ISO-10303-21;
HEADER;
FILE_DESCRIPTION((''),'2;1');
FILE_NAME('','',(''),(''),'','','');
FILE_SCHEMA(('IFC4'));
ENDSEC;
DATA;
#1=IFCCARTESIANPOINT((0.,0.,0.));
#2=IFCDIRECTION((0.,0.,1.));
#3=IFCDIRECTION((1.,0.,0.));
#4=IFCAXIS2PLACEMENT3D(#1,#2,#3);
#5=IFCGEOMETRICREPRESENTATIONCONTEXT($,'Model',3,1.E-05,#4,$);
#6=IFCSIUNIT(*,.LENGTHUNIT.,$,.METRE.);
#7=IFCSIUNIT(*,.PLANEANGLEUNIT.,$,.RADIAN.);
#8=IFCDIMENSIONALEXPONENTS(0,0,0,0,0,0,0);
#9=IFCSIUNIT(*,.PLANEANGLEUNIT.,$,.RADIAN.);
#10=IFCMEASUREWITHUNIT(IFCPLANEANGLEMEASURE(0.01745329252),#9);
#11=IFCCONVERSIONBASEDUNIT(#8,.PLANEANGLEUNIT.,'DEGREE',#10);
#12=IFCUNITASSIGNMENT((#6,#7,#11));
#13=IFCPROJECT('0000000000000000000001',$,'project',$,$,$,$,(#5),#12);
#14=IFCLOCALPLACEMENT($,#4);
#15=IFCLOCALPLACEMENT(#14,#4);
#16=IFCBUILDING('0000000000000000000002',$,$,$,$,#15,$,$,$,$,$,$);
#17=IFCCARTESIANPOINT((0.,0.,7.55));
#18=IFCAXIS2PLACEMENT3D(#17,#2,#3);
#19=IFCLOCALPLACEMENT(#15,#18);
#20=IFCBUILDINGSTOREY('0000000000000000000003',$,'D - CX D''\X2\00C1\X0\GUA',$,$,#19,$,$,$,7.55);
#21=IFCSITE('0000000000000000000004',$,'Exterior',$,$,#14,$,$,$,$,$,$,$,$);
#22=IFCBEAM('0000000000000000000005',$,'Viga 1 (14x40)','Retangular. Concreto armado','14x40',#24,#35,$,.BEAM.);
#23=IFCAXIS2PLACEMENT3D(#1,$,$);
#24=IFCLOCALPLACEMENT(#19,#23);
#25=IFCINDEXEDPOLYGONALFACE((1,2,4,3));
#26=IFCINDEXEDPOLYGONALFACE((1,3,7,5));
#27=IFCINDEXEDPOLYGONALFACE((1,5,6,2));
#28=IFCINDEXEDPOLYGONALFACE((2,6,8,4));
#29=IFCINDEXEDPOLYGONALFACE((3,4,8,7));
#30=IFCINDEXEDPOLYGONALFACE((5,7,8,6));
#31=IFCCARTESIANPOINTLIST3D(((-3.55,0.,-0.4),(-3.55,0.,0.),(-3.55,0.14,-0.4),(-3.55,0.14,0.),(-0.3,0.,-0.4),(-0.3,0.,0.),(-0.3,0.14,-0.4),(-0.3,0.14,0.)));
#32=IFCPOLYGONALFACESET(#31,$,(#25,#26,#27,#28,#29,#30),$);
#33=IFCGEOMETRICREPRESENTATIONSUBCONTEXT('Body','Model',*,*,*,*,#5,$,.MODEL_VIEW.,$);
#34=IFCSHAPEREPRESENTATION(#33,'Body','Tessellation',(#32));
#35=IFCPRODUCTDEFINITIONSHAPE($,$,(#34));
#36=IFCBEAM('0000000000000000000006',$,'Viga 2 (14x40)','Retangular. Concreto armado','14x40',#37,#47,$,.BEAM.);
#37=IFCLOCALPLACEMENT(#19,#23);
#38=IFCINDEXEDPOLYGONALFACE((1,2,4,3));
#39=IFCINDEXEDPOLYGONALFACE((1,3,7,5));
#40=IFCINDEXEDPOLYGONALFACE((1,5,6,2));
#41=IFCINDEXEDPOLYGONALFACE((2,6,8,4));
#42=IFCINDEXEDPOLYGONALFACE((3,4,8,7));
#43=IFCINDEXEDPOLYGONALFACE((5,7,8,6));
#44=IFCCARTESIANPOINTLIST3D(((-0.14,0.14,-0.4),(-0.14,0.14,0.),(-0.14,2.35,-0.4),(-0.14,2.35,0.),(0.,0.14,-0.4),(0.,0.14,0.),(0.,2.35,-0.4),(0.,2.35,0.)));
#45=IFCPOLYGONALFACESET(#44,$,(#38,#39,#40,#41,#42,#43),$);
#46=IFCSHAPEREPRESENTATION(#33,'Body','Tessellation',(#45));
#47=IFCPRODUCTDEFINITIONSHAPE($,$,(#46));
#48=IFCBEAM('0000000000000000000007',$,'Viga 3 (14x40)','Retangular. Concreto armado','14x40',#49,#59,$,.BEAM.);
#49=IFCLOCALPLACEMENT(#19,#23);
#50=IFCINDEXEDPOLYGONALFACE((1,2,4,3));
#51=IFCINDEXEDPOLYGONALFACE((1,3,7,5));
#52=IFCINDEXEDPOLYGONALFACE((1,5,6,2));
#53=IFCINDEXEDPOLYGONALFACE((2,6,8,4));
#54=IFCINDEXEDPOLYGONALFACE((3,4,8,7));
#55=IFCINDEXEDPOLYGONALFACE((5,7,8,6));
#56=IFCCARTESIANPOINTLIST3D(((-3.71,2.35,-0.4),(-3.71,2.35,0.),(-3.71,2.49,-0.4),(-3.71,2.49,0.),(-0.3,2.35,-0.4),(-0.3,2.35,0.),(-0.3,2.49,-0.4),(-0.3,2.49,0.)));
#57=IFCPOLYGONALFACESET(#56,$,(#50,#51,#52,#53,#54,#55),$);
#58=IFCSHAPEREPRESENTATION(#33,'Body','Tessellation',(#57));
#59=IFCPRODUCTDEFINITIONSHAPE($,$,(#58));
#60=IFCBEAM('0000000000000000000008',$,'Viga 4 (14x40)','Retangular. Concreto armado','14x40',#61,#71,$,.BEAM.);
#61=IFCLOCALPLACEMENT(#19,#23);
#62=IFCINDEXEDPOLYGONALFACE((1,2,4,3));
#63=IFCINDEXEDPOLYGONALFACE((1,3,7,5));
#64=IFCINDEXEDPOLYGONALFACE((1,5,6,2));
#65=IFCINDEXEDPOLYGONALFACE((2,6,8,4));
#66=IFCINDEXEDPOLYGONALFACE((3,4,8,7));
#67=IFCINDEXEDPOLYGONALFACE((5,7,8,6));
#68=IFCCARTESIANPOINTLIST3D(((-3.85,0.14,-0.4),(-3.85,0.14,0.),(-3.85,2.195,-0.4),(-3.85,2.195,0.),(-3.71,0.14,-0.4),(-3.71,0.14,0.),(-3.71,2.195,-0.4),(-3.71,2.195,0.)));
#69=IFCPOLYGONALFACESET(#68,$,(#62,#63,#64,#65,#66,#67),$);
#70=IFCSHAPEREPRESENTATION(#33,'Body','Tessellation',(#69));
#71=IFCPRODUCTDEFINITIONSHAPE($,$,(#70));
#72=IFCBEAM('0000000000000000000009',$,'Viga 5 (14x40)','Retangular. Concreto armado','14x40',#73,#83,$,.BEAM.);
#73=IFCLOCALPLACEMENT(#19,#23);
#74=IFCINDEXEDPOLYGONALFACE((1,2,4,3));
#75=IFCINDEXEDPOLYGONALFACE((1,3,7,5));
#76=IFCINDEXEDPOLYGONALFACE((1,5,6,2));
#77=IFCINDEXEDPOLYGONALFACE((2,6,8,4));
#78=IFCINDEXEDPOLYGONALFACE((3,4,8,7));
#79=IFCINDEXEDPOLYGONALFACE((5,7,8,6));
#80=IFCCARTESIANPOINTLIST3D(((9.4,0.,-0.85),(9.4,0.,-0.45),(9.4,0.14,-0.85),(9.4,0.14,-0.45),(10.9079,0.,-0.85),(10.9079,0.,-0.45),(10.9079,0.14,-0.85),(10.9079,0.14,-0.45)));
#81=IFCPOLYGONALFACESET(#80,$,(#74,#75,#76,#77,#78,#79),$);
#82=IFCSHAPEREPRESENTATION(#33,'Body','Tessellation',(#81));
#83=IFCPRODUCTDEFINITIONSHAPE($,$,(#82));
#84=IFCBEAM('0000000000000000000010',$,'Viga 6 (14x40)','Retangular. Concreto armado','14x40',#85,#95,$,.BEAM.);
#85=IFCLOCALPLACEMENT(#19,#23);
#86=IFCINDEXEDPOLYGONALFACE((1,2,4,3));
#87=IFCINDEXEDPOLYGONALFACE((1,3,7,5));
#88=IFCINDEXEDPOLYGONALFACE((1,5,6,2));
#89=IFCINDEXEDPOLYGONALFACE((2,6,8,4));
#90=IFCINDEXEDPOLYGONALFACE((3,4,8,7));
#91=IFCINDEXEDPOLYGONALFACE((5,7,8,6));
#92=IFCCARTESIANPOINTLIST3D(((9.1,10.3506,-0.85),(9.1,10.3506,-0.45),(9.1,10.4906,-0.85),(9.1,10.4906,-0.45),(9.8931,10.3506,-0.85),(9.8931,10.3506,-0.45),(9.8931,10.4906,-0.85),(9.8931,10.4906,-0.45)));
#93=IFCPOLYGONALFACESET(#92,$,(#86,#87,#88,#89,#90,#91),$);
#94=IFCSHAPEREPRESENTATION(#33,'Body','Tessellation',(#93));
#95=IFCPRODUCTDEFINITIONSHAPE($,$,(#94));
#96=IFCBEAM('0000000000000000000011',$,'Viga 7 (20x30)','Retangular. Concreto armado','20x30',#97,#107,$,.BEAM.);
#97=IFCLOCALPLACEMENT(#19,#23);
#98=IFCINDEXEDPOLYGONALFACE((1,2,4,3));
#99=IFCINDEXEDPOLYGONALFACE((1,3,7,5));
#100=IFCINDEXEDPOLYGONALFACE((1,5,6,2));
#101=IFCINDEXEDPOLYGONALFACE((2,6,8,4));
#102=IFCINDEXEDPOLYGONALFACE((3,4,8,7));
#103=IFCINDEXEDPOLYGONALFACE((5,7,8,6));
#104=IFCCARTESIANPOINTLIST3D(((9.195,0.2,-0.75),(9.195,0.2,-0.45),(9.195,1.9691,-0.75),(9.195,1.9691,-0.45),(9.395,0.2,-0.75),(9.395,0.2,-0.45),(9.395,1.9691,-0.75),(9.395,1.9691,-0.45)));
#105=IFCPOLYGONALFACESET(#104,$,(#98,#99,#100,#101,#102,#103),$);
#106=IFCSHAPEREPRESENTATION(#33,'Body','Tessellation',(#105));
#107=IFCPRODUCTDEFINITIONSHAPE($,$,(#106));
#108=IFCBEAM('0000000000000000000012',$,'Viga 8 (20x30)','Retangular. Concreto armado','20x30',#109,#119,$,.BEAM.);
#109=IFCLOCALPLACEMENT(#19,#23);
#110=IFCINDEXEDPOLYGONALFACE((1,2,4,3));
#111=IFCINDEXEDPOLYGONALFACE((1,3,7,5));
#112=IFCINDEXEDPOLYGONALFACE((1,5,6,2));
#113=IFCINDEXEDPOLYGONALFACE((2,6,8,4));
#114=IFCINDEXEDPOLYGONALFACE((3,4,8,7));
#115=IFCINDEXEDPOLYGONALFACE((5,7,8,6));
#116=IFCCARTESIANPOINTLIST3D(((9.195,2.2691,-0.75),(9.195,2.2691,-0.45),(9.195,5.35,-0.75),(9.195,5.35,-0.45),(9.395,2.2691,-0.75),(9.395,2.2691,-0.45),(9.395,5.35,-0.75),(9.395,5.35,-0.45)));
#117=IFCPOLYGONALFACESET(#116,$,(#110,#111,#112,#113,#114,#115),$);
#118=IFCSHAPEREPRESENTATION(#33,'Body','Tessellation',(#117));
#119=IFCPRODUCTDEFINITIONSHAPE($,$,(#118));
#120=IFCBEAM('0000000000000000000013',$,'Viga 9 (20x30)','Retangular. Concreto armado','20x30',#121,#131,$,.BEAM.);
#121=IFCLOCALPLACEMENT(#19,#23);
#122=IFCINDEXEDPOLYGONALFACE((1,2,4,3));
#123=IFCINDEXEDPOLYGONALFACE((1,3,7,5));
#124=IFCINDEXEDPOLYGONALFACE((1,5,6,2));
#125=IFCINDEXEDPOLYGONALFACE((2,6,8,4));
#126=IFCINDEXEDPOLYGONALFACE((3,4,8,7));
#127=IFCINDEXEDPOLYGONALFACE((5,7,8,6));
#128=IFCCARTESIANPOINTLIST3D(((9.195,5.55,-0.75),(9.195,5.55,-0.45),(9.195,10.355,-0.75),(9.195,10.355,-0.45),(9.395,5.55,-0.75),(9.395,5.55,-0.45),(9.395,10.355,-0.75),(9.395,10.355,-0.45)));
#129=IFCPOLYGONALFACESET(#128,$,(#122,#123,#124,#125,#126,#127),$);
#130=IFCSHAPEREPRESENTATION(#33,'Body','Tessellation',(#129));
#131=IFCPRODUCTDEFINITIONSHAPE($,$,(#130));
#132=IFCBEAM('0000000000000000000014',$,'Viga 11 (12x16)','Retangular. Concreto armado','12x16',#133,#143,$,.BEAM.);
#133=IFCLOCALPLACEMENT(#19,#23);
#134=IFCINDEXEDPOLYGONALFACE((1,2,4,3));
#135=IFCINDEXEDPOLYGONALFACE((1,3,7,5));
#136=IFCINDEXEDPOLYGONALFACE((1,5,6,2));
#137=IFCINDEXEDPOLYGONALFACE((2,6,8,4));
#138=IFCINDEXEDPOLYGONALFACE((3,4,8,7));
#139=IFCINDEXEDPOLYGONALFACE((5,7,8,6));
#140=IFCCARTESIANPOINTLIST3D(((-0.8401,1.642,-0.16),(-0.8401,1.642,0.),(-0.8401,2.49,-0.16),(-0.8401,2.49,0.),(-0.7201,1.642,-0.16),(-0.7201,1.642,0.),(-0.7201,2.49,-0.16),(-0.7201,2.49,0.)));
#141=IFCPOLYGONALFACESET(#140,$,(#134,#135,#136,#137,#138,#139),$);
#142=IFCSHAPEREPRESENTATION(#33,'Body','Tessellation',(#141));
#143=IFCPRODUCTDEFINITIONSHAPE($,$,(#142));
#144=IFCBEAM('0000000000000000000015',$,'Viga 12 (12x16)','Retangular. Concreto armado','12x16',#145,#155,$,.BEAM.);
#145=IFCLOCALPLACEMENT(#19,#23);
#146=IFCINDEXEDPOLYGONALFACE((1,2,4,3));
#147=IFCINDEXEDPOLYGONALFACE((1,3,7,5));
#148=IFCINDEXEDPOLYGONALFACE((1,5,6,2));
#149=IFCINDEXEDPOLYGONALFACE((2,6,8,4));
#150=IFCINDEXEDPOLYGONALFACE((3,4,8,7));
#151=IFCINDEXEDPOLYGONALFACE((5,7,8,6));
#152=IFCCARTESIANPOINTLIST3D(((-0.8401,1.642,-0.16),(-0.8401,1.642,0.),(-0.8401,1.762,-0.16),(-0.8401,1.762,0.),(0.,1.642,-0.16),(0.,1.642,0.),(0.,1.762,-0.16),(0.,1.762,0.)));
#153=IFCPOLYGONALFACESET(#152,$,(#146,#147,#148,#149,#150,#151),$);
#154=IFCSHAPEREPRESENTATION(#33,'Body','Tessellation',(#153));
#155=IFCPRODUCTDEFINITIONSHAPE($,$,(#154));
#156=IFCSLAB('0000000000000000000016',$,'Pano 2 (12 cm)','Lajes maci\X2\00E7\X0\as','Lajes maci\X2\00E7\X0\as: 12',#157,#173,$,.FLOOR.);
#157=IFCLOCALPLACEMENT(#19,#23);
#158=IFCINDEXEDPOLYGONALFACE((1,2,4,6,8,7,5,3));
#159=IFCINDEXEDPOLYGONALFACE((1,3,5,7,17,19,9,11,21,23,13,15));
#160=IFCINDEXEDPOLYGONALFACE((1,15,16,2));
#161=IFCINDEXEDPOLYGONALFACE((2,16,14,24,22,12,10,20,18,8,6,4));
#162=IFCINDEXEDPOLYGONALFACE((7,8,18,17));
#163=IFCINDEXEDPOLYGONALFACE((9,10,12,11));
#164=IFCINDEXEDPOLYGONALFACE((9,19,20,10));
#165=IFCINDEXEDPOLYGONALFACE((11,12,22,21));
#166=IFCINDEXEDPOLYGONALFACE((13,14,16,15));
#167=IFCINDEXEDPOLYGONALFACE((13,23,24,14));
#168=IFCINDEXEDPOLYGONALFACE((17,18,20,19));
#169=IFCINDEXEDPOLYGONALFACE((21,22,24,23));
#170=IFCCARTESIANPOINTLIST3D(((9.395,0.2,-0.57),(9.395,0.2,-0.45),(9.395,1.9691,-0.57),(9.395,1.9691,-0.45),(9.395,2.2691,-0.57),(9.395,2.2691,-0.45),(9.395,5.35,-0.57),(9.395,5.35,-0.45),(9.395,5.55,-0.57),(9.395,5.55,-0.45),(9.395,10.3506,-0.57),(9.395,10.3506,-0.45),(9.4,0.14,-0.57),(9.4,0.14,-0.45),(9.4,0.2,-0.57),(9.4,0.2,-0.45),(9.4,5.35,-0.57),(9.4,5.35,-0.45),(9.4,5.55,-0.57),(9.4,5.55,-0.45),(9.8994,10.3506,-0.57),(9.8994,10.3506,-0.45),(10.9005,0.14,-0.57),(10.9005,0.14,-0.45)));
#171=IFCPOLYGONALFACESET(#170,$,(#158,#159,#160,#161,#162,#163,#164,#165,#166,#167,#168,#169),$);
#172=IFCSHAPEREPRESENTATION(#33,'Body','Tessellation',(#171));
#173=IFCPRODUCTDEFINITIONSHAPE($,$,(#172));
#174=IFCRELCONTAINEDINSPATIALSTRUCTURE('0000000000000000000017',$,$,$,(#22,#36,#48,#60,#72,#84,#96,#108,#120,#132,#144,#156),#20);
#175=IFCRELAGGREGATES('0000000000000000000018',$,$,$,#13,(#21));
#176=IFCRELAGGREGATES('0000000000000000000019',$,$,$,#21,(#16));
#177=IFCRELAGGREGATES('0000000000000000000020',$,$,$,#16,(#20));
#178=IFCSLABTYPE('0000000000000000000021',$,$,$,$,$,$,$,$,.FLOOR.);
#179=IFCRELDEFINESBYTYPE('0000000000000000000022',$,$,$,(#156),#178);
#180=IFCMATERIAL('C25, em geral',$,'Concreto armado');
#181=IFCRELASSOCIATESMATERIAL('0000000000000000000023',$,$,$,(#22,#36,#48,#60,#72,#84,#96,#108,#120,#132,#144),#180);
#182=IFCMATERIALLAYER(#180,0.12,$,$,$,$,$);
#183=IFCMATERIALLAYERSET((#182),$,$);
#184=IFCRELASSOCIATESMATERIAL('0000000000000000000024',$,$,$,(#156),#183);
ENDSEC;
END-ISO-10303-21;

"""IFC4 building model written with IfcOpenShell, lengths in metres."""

from ifc_helpers import new_model, entity, si_unit, converted_unit, frame, frame_2d, origin_with_axes, place, context, subcontext, project, spatial, polyline, rectangle, outline, extrude, material, layer, layer_set, layer_usage, type_object, element, save


model = new_model("IFC4")

# Units and contexts
model_context = context("Model", 3, precision=1e-05, world=origin_with_axes())
body_context = subcontext(model_context, "Body", "Model", "MODEL_VIEW")
ifc_project = project(units=[si_unit("LENGTHUNIT", "METRE"), si_unit("PLANEANGLEUNIT", "RADIAN"), converted_unit("PLANEANGLEUNIT", "DEGREE", entity("IfcPlaneAngleMeasure", 0.01745329252), si_unit("PLANEANGLEUNIT", "RADIAN"), dimensions=[0, 0, 0, 0, 0, 0, 0])], contexts=[model_context])

# Site, building, storey
site_placement = place(None, origin_with_axes())
site = spatial("IfcSite", under=ifc_project, at=site_placement, Name="Exterior")
building_placement = place(site_placement, origin_with_axes())
building = spatial("IfcBuilding", under=site, at=building_placement)
storey_placement = place(building_placement, frame((0.0, 0.0, 7.55), z_axis=(0.0, 0.0, 1.0), x_axis=(1.0, 0.0, 0.0)))
storey = spatial("IfcBuildingStorey", under=building, at=storey_placement, Name="D - CX D'ÁGUA", Elevation=7.55)

# Beams
ifc_material = material(Name="C25, em geral", Category="Concreto armado")
beam_1_placement = place(storey_placement, frame((-3.55, 0.07, 0.0), z_axis=(1.0, 0.0, 0.0), x_axis=(0.0, 1.0, 0.0)))
element("IfcBeam", 1, at=beam_1_placement, inside=storey, material=ifc_material, Name="Viga 1 (14x40)", Description="Retangular. Concreto armado", ObjectType="14x40", PredefinedType="BEAM", context=body_context, shape_type="SweptSolid", body=[
    extrude(rectangle(XDim=0.14, YDim=0.4, at=frame_2d((0.0, -0.2), x_axis=(1.0, 0.0))), origin_with_axes(), (0.0, 0.0, 1.0), 3.25),
])
beam_2_placement = place(storey_placement, frame((-0.07, 0.14, 0.0), z_axis=(0.0, 1.0, 0.0), x_axis=(-1.0, 0.0, 0.0)))
element("IfcBeam", 2, at=beam_2_placement, inside=storey, material=ifc_material, Name="Viga 2 (14x40)", Description="Retangular. Concreto armado", ObjectType="14x40", PredefinedType="BEAM", context=body_context, shape_type="SweptSolid", body=[
    extrude(rectangle(XDim=0.14, YDim=0.4, at=frame_2d((0.0, -0.2), x_axis=(1.0, 0.0))), origin_with_axes(), (0.0, 0.0, 1.0), 2.21),
])
beam_3_placement = place(storey_placement, frame((-0.3, 2.42, 0.0), z_axis=(-1.0, 0.0, 0.0), x_axis=(0.0, -1.0, 0.0)))
element("IfcBeam", 3, at=beam_3_placement, inside=storey, material=ifc_material, Name="Viga 3 (14x40)", Description="Retangular. Concreto armado", ObjectType="14x40", PredefinedType="BEAM", context=body_context, shape_type="SweptSolid", body=[
    extrude(rectangle(XDim=0.14, YDim=0.4, at=frame_2d((0.0, -0.2), x_axis=(1.0, 0.0))), origin_with_axes(), (0.0, 0.0, 1.0), 3.41),
])
beam_4_placement = place(storey_placement, frame((-3.78, 0.14, 0.0), z_axis=(0.0, 1.0, 0.0), x_axis=(-1.0, 0.0, 0.0)))
element("IfcBeam", 4, at=beam_4_placement, inside=storey, material=ifc_material, Name="Viga 4 (14x40)", Description="Retangular. Concreto armado", ObjectType="14x40", PredefinedType="BEAM", context=body_context, shape_type="SweptSolid", body=[
    extrude(rectangle(XDim=0.14, YDim=0.4, at=frame_2d((0.0, -0.2), x_axis=(1.0, 0.0))), origin_with_axes(), (0.0, 0.0, 1.0), 2.055),
])
beam_5_placement = place(storey_placement, frame((9.4, 0.07, -0.45), z_axis=(1.0, 0.0, 0.0), x_axis=(0.0, 1.0, 0.0)))
element("IfcBeam", 5, at=beam_5_placement, inside=storey, material=ifc_material, Name="Viga 5 (14x40)", Description="Retangular. Concreto armado", ObjectType="14x40", PredefinedType="BEAM", context=body_context, shape_type="SweptSolid", body=[
    extrude(rectangle(XDim=0.14, YDim=0.4, at=frame_2d((0.0, -0.2), x_axis=(1.0, 0.0))), origin_with_axes(), (0.0, 0.0, 1.0), 1.5079),
])
beam_6_placement = place(storey_placement, frame((9.1, 10.4206, -0.45), z_axis=(1.0, 0.0, 0.0), x_axis=(0.0, 1.0, 0.0)))
element("IfcBeam", 6, at=beam_6_placement, inside=storey, material=ifc_material, Name="Viga 6 (14x40)", Description="Retangular. Concreto armado", ObjectType="14x40", PredefinedType="BEAM", context=body_context, shape_type="SweptSolid", body=[
    extrude(rectangle(XDim=0.14, YDim=0.4, at=frame_2d((0.0, -0.2), x_axis=(1.0, 0.0))), origin_with_axes(), (0.0, 0.0, 1.0), 0.7931),
])
beam_7_placement = place(storey_placement, frame((9.295, 1.9691, -0.45), z_axis=(0.0, -1.0, 0.0), x_axis=(1.0, 0.0, 0.0)))
element("IfcBeam", 7, at=beam_7_placement, inside=storey, material=ifc_material, Name="Viga 7 (20x30)", Description="Retangular. Concreto armado", ObjectType="20x30", PredefinedType="BEAM", context=body_context, shape_type="SweptSolid", body=[
    extrude(rectangle(XDim=0.2, YDim=0.3, at=frame_2d((0.0, -0.15), x_axis=(1.0, 0.0))), origin_with_axes(), (0.0, 0.0, 1.0), 1.7691),
])
beam_8_placement = place(storey_placement, frame((9.295, 2.2691, -0.45), z_axis=(0.0, 1.0, 0.0), x_axis=(-1.0, 0.0, 0.0)))
element("IfcBeam", 8, at=beam_8_placement, inside=storey, material=ifc_material, Name="Viga 8 (20x30)", Description="Retangular. Concreto armado", ObjectType="20x30", PredefinedType="BEAM", context=body_context, shape_type="SweptSolid", body=[
    extrude(rectangle(XDim=0.2, YDim=0.3, at=frame_2d((0.0, -0.15), x_axis=(1.0, 0.0))), origin_with_axes(), (0.0, 0.0, 1.0), 3.0809),
])
beam_9_placement = place(storey_placement, frame((9.295, 5.55, -0.45), z_axis=(0.0, 1.0, 0.0), x_axis=(-1.0, 0.0, 0.0)))
element("IfcBeam", 9, at=beam_9_placement, inside=storey, material=ifc_material, Name="Viga 9 (20x30)", Description="Retangular. Concreto armado", ObjectType="20x30", PredefinedType="BEAM", context=body_context, shape_type="SweptSolid", body=[
    extrude(rectangle(XDim=0.2, YDim=0.3, at=frame_2d((0.0, -0.15), x_axis=(1.0, 0.0))), origin_with_axes(), (0.0, 0.0, 1.0), 4.805),
])
beam_10_placement = place(storey_placement, frame((-0.7801, 2.49, 0.0), z_axis=(0.0, -1.0, 0.0), x_axis=(1.0, 0.0, 0.0)))
element("IfcBeam", 10, at=beam_10_placement, inside=storey, material=ifc_material, Name="Viga 11 (12x16)", Description="Retangular. Concreto armado", ObjectType="12x16", PredefinedType="BEAM", context=body_context, shape_type="SweptSolid", body=[
    extrude(rectangle(XDim=0.12, YDim=0.16, at=frame_2d((0.0, -0.08), x_axis=(1.0, 0.0))), origin_with_axes(), (0.0, 0.0, 1.0), 0.848),
])
beam_11_placement = place(storey_placement, frame((-0.8401, 1.702, 0.0), z_axis=(1.0, 0.0, 0.0), x_axis=(0.0, 1.0, 0.0)))
element("IfcBeam", 11, at=beam_11_placement, inside=storey, material=ifc_material, Name="Viga 12 (12x16)", Description="Retangular. Concreto armado", ObjectType="12x16", PredefinedType="BEAM", context=body_context, shape_type="SweptSolid", body=[
    extrude(rectangle(XDim=0.12, YDim=0.16, at=frame_2d((0.0, -0.08), x_axis=(1.0, 0.0))), origin_with_axes(), (0.0, 0.0, 1.0), 0.8401),
])

# Slab
ifc_layer = layer(ifc_material, 0.12)
ifc_layer_set = layer_set([ifc_layer])
ifc_layer_usage = layer_usage(ifc_layer_set, "AXIS3", "POSITIVE", 0.0)
slab_type = type_object("IfcSlabType", PredefinedType="FLOOR")
slab_placement = place(storey_placement, frame((0.0, 0.0, -0.57), z_axis=(0.0, 0.0, 1.0), x_axis=(1.0, 0.0, 0.0)))
element("IfcSlab", 12, at=slab_placement, inside=storey, type_object=slab_type, material=ifc_layer_usage, Name="Pano 2 (12 cm)", Description="Lajes maciças", ObjectType="Lajes maciças: 12", PredefinedType="FLOOR", context=body_context, shape_type="SweptSolid", body=[
    extrude(outline(polyline([(9.395, 10.3506), (9.395, 5.55), (9.4, 5.55), (9.4, 5.35), (9.395, 5.35), (9.395, 2.2691), (9.395, 1.9691), (9.395, 0.2), (9.4, 0.2), (9.4, 0.14), (10.9005, 0.14), (9.8994, 10.3506), (9.395, 10.3506)])), origin_with_axes(), (0.0, 0.0, 1.0), 0.12),
])

save(model, "model.ifc")
